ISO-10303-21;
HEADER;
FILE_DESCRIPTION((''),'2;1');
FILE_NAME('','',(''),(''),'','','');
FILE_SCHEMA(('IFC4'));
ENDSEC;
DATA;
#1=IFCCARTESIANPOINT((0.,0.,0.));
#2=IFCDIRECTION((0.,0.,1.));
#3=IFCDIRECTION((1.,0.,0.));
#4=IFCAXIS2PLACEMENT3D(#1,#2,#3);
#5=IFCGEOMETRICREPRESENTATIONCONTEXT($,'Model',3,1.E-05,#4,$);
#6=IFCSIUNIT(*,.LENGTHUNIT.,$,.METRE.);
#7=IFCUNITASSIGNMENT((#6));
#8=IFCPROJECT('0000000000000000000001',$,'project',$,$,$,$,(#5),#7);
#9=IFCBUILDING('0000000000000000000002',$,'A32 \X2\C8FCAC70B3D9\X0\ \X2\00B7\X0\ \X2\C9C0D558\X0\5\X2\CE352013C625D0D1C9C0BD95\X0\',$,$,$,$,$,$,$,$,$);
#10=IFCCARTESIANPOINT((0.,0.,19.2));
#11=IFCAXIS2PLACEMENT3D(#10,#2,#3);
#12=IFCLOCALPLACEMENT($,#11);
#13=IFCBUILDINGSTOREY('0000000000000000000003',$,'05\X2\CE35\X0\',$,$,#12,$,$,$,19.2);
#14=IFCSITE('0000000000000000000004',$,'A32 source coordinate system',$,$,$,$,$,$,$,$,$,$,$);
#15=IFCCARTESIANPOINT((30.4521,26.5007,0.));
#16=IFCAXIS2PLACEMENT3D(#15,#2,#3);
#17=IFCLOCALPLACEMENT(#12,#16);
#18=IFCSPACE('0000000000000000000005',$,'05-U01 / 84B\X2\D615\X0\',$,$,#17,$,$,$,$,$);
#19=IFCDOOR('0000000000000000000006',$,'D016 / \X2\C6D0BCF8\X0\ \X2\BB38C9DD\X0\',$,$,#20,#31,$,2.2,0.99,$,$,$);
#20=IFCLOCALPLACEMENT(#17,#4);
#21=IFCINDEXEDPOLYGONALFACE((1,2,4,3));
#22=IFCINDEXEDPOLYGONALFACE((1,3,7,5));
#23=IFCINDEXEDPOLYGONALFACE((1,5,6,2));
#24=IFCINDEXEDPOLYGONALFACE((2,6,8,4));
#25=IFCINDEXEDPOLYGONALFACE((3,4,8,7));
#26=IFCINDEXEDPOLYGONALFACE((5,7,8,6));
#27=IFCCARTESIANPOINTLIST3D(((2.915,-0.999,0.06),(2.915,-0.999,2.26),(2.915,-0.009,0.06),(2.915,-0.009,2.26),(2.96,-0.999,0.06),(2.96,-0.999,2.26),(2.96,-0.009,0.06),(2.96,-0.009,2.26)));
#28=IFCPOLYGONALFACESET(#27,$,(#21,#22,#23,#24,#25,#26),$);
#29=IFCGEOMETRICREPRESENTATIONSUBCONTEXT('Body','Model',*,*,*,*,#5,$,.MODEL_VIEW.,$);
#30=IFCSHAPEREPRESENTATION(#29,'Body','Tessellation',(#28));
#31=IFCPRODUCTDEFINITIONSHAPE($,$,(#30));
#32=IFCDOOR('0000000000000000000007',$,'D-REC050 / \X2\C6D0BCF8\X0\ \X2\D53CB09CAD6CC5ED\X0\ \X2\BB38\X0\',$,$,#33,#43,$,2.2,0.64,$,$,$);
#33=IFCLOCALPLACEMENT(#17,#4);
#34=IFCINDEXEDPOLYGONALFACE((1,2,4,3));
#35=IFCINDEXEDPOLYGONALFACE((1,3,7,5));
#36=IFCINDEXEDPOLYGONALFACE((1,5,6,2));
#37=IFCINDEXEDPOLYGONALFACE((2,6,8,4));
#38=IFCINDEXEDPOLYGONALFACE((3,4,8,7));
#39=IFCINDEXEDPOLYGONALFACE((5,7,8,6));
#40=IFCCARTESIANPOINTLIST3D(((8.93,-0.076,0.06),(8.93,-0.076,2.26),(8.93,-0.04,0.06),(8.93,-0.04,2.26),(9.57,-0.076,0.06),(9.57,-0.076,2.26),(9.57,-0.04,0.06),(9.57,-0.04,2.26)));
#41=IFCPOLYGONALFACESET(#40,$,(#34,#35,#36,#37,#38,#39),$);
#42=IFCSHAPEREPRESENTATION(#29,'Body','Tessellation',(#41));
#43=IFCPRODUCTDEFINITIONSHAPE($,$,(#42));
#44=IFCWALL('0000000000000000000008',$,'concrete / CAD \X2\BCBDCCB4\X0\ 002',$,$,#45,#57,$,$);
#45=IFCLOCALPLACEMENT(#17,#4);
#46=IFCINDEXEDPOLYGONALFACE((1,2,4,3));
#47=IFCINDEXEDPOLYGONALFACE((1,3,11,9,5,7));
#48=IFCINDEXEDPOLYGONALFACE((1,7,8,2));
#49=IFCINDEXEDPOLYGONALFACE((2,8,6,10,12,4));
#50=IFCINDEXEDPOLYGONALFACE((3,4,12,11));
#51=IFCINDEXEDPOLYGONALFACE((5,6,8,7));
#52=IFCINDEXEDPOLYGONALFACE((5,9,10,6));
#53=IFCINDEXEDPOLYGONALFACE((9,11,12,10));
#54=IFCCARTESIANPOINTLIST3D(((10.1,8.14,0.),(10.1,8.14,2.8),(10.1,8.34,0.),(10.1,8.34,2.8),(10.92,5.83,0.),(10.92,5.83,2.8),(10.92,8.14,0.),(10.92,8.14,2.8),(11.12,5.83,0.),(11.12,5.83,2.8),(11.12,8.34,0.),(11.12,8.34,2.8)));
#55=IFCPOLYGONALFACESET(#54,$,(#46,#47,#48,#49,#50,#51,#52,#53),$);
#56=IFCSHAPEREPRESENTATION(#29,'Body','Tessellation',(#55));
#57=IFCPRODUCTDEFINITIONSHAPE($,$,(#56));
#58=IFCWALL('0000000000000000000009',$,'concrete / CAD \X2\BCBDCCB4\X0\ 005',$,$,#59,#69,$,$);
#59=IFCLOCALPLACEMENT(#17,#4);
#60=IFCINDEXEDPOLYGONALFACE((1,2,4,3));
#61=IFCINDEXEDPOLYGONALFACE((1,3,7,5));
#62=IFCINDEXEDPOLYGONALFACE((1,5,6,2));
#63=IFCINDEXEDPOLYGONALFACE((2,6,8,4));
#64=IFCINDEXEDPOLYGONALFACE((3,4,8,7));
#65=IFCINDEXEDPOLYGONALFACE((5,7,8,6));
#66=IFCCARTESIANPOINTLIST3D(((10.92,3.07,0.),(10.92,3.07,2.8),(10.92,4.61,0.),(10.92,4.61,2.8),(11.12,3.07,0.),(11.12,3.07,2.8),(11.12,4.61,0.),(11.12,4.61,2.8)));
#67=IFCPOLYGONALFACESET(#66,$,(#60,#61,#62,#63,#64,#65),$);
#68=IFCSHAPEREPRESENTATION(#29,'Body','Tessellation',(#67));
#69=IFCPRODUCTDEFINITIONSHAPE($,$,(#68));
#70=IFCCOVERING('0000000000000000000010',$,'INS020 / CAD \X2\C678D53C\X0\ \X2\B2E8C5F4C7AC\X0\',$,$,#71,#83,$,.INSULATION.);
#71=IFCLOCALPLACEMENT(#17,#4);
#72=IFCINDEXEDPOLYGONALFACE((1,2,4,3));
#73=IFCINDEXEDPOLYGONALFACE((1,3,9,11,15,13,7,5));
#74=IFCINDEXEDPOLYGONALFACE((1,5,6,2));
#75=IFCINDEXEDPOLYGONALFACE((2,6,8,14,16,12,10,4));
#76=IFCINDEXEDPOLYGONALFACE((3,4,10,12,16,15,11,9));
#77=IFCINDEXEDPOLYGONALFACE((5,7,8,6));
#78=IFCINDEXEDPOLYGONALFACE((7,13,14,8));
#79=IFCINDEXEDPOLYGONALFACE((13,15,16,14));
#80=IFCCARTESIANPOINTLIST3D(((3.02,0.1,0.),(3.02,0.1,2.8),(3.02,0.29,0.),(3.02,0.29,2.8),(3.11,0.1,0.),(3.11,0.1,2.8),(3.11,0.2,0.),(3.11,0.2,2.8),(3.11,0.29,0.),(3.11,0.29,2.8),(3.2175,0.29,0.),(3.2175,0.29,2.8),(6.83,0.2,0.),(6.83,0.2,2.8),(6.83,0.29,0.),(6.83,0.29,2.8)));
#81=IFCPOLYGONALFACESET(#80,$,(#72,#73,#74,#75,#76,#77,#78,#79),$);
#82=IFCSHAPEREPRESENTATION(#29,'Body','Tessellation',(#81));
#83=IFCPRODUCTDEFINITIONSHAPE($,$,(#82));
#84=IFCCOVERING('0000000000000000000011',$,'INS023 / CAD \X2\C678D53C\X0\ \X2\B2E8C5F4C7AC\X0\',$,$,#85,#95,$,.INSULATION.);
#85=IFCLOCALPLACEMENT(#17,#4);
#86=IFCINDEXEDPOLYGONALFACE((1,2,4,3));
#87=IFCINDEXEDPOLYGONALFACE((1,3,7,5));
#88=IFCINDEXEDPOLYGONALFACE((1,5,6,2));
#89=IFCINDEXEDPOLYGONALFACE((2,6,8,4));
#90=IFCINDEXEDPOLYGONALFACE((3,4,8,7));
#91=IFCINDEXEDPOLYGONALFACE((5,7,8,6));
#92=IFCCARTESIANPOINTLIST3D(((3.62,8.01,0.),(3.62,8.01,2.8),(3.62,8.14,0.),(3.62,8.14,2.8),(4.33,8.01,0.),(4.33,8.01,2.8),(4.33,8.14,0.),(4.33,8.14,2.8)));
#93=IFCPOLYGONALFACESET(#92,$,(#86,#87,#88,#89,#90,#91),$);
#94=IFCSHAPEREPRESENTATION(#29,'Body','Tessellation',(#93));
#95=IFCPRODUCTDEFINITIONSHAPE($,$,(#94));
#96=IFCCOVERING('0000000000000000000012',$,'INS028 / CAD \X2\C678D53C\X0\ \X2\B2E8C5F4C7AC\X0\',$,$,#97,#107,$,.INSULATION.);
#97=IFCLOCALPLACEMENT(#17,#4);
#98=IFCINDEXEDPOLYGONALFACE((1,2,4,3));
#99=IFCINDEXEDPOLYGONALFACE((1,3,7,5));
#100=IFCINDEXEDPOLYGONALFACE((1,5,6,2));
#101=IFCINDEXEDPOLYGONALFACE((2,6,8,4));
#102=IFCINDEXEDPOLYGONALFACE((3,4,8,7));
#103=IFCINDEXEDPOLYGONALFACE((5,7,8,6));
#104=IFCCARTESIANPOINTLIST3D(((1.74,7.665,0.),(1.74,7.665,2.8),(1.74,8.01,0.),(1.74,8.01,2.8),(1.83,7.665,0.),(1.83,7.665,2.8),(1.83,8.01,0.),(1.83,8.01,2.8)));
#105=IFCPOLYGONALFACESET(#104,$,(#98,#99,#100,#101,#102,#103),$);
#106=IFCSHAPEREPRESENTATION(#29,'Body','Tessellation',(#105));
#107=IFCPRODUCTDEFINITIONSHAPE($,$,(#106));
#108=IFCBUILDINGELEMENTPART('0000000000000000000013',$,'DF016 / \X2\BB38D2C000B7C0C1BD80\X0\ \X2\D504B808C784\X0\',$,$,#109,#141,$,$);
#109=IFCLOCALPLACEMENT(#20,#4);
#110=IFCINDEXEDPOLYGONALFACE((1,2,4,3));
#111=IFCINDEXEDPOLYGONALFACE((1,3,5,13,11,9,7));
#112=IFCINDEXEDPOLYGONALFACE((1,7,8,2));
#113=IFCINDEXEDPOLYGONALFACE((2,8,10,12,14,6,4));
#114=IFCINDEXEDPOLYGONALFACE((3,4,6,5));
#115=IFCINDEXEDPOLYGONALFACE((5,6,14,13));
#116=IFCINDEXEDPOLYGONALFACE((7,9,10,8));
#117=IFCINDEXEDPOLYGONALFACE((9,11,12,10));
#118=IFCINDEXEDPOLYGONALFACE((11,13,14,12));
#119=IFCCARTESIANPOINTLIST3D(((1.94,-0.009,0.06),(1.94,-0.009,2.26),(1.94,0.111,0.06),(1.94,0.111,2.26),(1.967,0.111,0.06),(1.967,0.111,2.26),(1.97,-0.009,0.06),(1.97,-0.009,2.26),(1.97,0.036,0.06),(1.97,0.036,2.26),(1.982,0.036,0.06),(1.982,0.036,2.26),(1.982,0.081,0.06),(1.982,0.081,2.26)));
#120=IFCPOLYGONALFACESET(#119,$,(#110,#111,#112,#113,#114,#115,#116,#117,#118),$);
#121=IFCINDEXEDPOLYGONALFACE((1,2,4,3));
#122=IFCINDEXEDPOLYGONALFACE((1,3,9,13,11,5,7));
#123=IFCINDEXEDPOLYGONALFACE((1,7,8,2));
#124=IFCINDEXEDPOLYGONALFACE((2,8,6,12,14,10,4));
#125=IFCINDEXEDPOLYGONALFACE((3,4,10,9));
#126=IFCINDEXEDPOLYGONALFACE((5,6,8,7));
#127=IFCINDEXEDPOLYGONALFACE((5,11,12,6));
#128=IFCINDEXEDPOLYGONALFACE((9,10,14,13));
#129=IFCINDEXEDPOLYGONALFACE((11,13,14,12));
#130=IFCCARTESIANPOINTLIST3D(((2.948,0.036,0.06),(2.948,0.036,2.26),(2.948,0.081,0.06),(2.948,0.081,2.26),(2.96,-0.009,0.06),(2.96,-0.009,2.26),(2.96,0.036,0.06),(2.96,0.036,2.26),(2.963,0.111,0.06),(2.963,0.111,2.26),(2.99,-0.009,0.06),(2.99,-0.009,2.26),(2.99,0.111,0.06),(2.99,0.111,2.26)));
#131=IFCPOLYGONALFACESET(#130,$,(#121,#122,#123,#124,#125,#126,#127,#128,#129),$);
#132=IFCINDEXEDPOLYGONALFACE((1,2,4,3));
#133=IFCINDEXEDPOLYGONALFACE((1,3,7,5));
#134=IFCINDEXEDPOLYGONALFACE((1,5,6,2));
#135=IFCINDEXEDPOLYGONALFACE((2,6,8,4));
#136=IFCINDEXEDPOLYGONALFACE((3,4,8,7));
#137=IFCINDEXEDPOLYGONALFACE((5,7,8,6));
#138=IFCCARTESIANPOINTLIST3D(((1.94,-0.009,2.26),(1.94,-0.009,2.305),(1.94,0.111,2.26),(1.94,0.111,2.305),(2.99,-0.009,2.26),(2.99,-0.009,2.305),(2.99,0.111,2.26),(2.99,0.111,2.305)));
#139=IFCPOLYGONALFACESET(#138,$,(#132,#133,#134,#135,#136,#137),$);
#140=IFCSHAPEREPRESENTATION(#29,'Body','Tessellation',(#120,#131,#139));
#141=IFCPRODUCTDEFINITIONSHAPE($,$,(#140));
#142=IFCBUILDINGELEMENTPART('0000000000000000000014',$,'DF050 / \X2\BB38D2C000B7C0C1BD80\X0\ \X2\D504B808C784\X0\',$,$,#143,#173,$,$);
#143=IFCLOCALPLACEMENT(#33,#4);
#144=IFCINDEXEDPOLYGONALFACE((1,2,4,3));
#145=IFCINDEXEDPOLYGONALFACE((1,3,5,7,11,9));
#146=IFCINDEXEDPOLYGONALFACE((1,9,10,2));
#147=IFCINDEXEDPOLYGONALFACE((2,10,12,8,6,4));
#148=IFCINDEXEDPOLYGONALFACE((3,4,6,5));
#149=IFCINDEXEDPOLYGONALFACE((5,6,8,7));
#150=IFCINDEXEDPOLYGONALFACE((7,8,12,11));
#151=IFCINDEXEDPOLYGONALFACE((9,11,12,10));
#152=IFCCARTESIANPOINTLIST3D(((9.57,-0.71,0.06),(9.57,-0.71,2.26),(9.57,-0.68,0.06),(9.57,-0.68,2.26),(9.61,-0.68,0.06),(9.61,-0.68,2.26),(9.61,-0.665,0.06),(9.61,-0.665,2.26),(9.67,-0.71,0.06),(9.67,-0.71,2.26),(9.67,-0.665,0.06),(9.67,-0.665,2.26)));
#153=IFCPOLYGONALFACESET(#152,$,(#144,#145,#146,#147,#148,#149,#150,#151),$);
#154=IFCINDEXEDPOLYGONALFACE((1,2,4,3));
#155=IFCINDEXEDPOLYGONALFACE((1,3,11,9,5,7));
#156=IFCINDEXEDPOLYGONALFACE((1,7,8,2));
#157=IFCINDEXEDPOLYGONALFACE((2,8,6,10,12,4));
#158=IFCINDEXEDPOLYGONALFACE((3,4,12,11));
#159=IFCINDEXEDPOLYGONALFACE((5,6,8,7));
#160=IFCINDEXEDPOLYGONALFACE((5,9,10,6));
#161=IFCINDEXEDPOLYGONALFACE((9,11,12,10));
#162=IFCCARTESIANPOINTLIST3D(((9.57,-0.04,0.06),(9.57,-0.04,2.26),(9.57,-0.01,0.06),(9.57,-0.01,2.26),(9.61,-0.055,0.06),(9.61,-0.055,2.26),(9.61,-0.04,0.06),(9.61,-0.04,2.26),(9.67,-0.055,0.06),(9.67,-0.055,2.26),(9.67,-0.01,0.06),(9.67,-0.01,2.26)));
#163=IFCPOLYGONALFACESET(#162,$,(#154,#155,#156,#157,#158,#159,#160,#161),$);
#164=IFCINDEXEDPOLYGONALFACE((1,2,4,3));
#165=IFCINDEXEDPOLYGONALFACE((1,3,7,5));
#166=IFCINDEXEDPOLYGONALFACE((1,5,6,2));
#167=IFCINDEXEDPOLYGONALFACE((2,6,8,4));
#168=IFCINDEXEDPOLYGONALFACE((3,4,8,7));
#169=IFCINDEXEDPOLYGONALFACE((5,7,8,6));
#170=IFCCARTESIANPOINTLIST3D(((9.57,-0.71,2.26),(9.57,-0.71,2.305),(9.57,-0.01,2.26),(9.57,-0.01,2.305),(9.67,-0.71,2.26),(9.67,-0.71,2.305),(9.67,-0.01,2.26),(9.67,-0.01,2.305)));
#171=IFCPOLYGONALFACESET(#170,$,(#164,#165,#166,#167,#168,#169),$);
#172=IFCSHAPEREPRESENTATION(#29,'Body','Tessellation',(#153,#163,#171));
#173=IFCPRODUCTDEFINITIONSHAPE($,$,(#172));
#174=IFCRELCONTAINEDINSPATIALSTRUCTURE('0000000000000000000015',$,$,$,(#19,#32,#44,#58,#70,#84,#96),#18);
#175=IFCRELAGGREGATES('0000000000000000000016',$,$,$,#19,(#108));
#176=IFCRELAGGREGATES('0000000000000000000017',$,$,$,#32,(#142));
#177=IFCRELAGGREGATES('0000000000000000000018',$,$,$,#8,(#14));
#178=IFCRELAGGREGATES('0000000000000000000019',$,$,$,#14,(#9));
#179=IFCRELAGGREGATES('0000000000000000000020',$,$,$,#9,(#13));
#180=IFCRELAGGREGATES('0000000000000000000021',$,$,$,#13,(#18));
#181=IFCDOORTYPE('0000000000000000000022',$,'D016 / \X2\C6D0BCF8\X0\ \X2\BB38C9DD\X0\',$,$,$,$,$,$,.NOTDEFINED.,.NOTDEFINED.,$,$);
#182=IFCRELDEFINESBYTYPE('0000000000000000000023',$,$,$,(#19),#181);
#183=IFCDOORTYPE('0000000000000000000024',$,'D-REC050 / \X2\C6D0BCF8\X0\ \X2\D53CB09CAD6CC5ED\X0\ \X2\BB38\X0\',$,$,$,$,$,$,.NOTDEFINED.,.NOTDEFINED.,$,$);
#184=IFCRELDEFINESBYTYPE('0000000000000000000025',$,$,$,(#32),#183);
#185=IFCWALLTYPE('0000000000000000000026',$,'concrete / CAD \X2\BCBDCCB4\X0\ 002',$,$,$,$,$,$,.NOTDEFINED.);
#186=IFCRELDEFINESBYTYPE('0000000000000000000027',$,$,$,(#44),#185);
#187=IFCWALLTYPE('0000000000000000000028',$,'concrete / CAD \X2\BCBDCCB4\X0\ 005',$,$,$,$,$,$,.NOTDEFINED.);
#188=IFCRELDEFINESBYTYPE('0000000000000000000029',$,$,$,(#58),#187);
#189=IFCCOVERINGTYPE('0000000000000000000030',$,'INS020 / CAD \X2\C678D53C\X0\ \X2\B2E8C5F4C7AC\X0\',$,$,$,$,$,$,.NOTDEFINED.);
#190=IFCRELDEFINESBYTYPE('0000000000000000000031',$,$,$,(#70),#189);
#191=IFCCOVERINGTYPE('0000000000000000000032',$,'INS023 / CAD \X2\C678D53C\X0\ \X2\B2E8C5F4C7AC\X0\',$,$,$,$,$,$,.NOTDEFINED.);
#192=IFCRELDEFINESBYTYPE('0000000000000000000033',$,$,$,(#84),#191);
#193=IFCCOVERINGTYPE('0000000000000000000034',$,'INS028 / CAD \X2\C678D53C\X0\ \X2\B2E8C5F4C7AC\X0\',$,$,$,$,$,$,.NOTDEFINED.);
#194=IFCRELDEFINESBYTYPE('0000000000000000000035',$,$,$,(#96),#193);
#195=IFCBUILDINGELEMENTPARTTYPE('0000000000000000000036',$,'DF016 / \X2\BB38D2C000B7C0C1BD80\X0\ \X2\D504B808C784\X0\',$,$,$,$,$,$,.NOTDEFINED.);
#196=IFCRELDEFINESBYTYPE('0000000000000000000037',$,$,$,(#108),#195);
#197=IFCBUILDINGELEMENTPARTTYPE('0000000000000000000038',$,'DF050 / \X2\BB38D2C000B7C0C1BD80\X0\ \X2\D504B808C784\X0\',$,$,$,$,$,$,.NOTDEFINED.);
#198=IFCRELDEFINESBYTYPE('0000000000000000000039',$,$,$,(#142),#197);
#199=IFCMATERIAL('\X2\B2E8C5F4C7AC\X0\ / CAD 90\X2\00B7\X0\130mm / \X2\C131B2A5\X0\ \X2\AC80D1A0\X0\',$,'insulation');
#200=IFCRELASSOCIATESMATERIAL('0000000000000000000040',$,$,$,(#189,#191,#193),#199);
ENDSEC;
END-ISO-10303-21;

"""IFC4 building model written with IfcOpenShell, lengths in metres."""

from ifc_helpers import new_model, si_unit, frame, origin, origin_with_axes, place, context, subcontext, project, spatial, polyline, outline, extrude, source, transform, mapped, material, type_object, type_shapes, element, aggregate, save


model = new_model("IFC4")

# Units and contexts
model_context = context("Model", 3, precision=1e-05, world=origin_with_axes())
body_context = subcontext(model_context, "Body", "Model", "MODEL_VIEW")
ifc_project = project(units=[si_unit("LENGTHUNIT", "METRE")], contexts=[model_context])

# Site, building, storey, space
storey_placement = place(None, frame((0.0, 0.0, 19.2), z_axis=(0.0, 0.0, 1.0), x_axis=(1.0, 0.0, 0.0)))
space_placement = place(storey_placement, frame((30.4521, 26.5007, 0.0), z_axis=(0.0, 0.0, 1.0), x_axis=(1.0, 0.0, 0.0)))
site = spatial("IfcSite", under=ifc_project, Name="A32 source coordinate system")
building = spatial("IfcBuilding", under=site, Name="A32 주거동 · 지하5층–옥탑지붕")
storey = spatial("IfcBuildingStorey", under=building, at=storey_placement, Name="05층", Elevation=19.2)
space = spatial("IfcSpace", under=storey, at=space_placement, Name="05-U01 / 84B형")

# Doors
door_type_1 = type_object("IfcDoorType", Name="D016 / 원본 문짝", OperationType="NOTDEFINED", PredefinedType="NOTDEFINED")
shared_shape_1 = source(origin(), body_context, "Body", "SweptSolid", [
    extrude(outline(polyline([(2.96, -0.009), (2.96, -0.999), (2.915, -0.999), (2.915, -0.009), (2.96, -0.009)])), frame((0.0, 0.0, 0.06)), (0.0, 0.0, 1.0), 2.2),
])
type_shapes(door_type_1, [shared_shape_1])
door_1_placement = place(space_placement, origin_with_axes())
door_1 = element("IfcDoor", 1, at=door_1_placement, inside=space, type_object=door_type_1, Name="D016 / 원본 문짝", OverallHeight=2.2, OverallWidth=0.99, context=body_context, shape_type="MappedRepresentation", body=[
    mapped(shared_shape_1, transform((0.0, 0.0, 0.0), scale=1.0)),
])
door_type_2 = type_object("IfcDoorType", Name="D-REC050 / 원본 피난구역 문", OperationType="NOTDEFINED", PredefinedType="NOTDEFINED")
shared_shape_2 = source(origin(), body_context, "Body", "SweptSolid", [
    extrude(outline(polyline([(9.57, -0.04), (9.57, -0.076), (8.93, -0.076), (8.93, -0.04), (9.57, -0.04)])), frame((0.0, 0.0, 0.06)), (0.0, 0.0, 1.0), 2.2),
])
type_shapes(door_type_2, [shared_shape_2])
door_2_placement = place(space_placement, origin_with_axes())
door_2 = element("IfcDoor", 2, at=door_2_placement, inside=space, type_object=door_type_2, Name="D-REC050 / 원본 피난구역 문", OverallHeight=2.2, OverallWidth=0.64, context=body_context, shape_type="MappedRepresentation", body=[
    mapped(shared_shape_2, transform((0.0, 0.0, 0.0), scale=1.0)),
])

# Walls
wall_type_1 = type_object("IfcWallType", Name="concrete / CAD 벽체 002", PredefinedType="NOTDEFINED")
shared_shape_3 = source(origin(), body_context, "Body", "SweptSolid", [
    extrude(outline(polyline([(11.12, 5.83), (10.92, 5.83), (10.92, 8.14), (10.1, 8.14), (10.1, 8.34), (11.12, 8.34), (11.12, 5.83)])), origin(), (0.0, 0.0, 1.0), 2.8),
])
type_shapes(wall_type_1, [shared_shape_3])
wall_1_placement = place(space_placement, origin_with_axes())
element("IfcWall", 3, at=wall_1_placement, inside=space, type_object=wall_type_1, Name="concrete / CAD 벽체 002", context=body_context, shape_type="MappedRepresentation", body=[
    mapped(shared_shape_3, transform((0.0, 0.0, 0.0), scale=1.0)),
])
wall_type_2 = type_object("IfcWallType", Name="concrete / CAD 벽체 005", PredefinedType="NOTDEFINED")
shared_shape_4 = source(origin(), body_context, "Body", "SweptSolid", [
    extrude(outline(polyline([(11.12, 3.07), (10.92, 3.07), (10.92, 4.61), (11.12, 4.61), (11.12, 3.07)])), origin(), (0.0, 0.0, 1.0), 2.8),
])
type_shapes(wall_type_2, [shared_shape_4])
wall_2_placement = place(space_placement, origin_with_axes())
element("IfcWall", 4, at=wall_2_placement, inside=space, type_object=wall_type_2, Name="concrete / CAD 벽체 005", context=body_context, shape_type="MappedRepresentation", body=[
    mapped(shared_shape_4, transform((0.0, 0.0, 0.0), scale=1.0)),
])

# Coverings
ifc_material = material(Name="단열재 / CAD 90·130mm / 성능 검토", Category="insulation")
covering_type_1 = type_object("IfcCoveringType", Name="INS020 / CAD 외피 단열재", PredefinedType="NOTDEFINED", material=ifc_material)
shared_shape_5 = source(origin(), body_context, "Body", "SweptSolid", [
    extrude(outline(polyline([(3.11, 0.2), (3.11, 0.1), (3.02, 0.1), (3.02, 0.29), (3.11, 0.29), (3.2175, 0.29), (6.83, 0.29), (6.83, 0.2), (3.11, 0.2)])), origin(), (0.0, 0.0, 1.0), 2.8),
])
type_shapes(covering_type_1, [shared_shape_5])
covering_1_placement = place(space_placement, origin_with_axes())
element("IfcCovering", 5, at=covering_1_placement, inside=space, type_object=covering_type_1, Name="INS020 / CAD 외피 단열재", PredefinedType="INSULATION", context=body_context, shape_type="MappedRepresentation", body=[
    mapped(shared_shape_5, transform((0.0, 0.0, 0.0), scale=1.0)),
])
covering_type_2 = type_object("IfcCoveringType", Name="INS023 / CAD 외피 단열재", PredefinedType="NOTDEFINED", material=ifc_material)
shared_shape_6 = source(origin(), body_context, "Body", "SweptSolid", [
    extrude(outline(polyline([(4.33, 8.01), (3.62, 8.01), (3.62, 8.14), (4.33, 8.14), (4.33, 8.01)])), origin(), (0.0, 0.0, 1.0), 2.8),
])
type_shapes(covering_type_2, [shared_shape_6])
covering_2_placement = place(space_placement, origin_with_axes())
element("IfcCovering", 6, at=covering_2_placement, inside=space, type_object=covering_type_2, Name="INS023 / CAD 외피 단열재", PredefinedType="INSULATION", context=body_context, shape_type="MappedRepresentation", body=[
    mapped(shared_shape_6, transform((0.0, 0.0, 0.0), scale=1.0)),
])
covering_type_3 = type_object("IfcCoveringType", Name="INS028 / CAD 외피 단열재", PredefinedType="NOTDEFINED", material=ifc_material)
shared_shape_7 = source(origin(), body_context, "Body", "SweptSolid", [
    extrude(outline(polyline([(1.74, 8.01), (1.83, 8.01), (1.83, 7.665), (1.74, 7.665), (1.74, 8.01)])), origin(), (0.0, 0.0, 1.0), 2.8),
])
type_shapes(covering_type_3, [shared_shape_7])
covering_3_placement = place(space_placement, origin_with_axes())
element("IfcCovering", 7, at=covering_3_placement, inside=space, type_object=covering_type_3, Name="INS028 / CAD 외피 단열재", PredefinedType="INSULATION", context=body_context, shape_type="MappedRepresentation", body=[
    mapped(shared_shape_7, transform((0.0, 0.0, 0.0), scale=1.0)),
])

# Building element parts
building_element_part_type_1 = type_object("IfcBuildingElementPartType", Name="DF016 / 문틀·상부 프레임", PredefinedType="NOTDEFINED")
shared_shape_8 = source(origin(), body_context, "Body", "SweptSolid", [
    extrude(outline(polyline([(1.94, 0.111), (1.967, 0.111), (1.982, 0.081), (1.982, 0.036), (1.97, 0.036), (1.97, -0.009), (1.94, -0.009), (1.94, 0.111)])), frame((0.0, 0.0, 0.06)), (0.0, 0.0, 1.0), 2.2),
    extrude(outline(polyline([(2.96, -0.009), (2.96, 0.036), (2.948, 0.036), (2.948, 0.081), (2.963, 0.111), (2.99, 0.111), (2.99, -0.009), (2.96, -0.009)])), frame((0.0, 0.0, 0.06)), (0.0, 0.0, 1.0), 2.2),
    extrude(outline(polyline([(1.94, -0.009), (1.94, 0.111), (2.99, 0.111), (2.99, -0.009), (1.94, -0.009)])), frame((0.0, 0.0, 2.26)), (0.0, 0.0, 1.0), 0.045),
])
type_shapes(building_element_part_type_1, [shared_shape_8])
building_element_part_1_placement = place(door_1_placement, origin_with_axes())
building_element_part_1 = element("IfcBuildingElementPart", 8, at=building_element_part_1_placement, type_object=building_element_part_type_1, Name="DF016 / 문틀·상부 프레임", context=body_context, shape_type="MappedRepresentation", body=[
    mapped(shared_shape_8, transform((0.0, 0.0, 0.0), scale=1.0)),
])
aggregate(door_1, [building_element_part_1])
building_element_part_type_2 = type_object("IfcBuildingElementPartType", Name="DF050 / 문틀·상부 프레임", PredefinedType="NOTDEFINED")
shared_shape_9 = source(origin(), body_context, "Body", "SweptSolid", [
    extrude(outline(polyline([(9.57, -0.68), (9.61, -0.68), (9.61, -0.665), (9.67, -0.665), (9.67, -0.71), (9.57, -0.71), (9.57, -0.68)])), frame((0.0, 0.0, 0.06)), (0.0, 0.0, 1.0), 2.2),
    extrude(outline(polyline([(9.67, -0.01), (9.67, -0.055), (9.61, -0.055), (9.61, -0.04), (9.57, -0.04), (9.57, -0.01), (9.67, -0.01)])), frame((0.0, 0.0, 0.06)), (0.0, 0.0, 1.0), 2.2),
    extrude(outline(polyline([(9.57, -0.71), (9.57, -0.01), (9.67, -0.01), (9.67, -0.71), (9.57, -0.71)])), frame((0.0, 0.0, 2.26)), (0.0, 0.0, 1.0), 0.045),
])
type_shapes(building_element_part_type_2, [shared_shape_9])
building_element_part_2_placement = place(door_2_placement, origin_with_axes())
building_element_part_2 = element("IfcBuildingElementPart", 9, at=building_element_part_2_placement, type_object=building_element_part_type_2, Name="DF050 / 문틀·상부 프레임", context=body_context, shape_type="MappedRepresentation", body=[
    mapped(shared_shape_9, transform((0.0, 0.0, 0.0), scale=1.0)),
])
aggregate(door_2, [building_element_part_2])

save(model, "model.ifc")
